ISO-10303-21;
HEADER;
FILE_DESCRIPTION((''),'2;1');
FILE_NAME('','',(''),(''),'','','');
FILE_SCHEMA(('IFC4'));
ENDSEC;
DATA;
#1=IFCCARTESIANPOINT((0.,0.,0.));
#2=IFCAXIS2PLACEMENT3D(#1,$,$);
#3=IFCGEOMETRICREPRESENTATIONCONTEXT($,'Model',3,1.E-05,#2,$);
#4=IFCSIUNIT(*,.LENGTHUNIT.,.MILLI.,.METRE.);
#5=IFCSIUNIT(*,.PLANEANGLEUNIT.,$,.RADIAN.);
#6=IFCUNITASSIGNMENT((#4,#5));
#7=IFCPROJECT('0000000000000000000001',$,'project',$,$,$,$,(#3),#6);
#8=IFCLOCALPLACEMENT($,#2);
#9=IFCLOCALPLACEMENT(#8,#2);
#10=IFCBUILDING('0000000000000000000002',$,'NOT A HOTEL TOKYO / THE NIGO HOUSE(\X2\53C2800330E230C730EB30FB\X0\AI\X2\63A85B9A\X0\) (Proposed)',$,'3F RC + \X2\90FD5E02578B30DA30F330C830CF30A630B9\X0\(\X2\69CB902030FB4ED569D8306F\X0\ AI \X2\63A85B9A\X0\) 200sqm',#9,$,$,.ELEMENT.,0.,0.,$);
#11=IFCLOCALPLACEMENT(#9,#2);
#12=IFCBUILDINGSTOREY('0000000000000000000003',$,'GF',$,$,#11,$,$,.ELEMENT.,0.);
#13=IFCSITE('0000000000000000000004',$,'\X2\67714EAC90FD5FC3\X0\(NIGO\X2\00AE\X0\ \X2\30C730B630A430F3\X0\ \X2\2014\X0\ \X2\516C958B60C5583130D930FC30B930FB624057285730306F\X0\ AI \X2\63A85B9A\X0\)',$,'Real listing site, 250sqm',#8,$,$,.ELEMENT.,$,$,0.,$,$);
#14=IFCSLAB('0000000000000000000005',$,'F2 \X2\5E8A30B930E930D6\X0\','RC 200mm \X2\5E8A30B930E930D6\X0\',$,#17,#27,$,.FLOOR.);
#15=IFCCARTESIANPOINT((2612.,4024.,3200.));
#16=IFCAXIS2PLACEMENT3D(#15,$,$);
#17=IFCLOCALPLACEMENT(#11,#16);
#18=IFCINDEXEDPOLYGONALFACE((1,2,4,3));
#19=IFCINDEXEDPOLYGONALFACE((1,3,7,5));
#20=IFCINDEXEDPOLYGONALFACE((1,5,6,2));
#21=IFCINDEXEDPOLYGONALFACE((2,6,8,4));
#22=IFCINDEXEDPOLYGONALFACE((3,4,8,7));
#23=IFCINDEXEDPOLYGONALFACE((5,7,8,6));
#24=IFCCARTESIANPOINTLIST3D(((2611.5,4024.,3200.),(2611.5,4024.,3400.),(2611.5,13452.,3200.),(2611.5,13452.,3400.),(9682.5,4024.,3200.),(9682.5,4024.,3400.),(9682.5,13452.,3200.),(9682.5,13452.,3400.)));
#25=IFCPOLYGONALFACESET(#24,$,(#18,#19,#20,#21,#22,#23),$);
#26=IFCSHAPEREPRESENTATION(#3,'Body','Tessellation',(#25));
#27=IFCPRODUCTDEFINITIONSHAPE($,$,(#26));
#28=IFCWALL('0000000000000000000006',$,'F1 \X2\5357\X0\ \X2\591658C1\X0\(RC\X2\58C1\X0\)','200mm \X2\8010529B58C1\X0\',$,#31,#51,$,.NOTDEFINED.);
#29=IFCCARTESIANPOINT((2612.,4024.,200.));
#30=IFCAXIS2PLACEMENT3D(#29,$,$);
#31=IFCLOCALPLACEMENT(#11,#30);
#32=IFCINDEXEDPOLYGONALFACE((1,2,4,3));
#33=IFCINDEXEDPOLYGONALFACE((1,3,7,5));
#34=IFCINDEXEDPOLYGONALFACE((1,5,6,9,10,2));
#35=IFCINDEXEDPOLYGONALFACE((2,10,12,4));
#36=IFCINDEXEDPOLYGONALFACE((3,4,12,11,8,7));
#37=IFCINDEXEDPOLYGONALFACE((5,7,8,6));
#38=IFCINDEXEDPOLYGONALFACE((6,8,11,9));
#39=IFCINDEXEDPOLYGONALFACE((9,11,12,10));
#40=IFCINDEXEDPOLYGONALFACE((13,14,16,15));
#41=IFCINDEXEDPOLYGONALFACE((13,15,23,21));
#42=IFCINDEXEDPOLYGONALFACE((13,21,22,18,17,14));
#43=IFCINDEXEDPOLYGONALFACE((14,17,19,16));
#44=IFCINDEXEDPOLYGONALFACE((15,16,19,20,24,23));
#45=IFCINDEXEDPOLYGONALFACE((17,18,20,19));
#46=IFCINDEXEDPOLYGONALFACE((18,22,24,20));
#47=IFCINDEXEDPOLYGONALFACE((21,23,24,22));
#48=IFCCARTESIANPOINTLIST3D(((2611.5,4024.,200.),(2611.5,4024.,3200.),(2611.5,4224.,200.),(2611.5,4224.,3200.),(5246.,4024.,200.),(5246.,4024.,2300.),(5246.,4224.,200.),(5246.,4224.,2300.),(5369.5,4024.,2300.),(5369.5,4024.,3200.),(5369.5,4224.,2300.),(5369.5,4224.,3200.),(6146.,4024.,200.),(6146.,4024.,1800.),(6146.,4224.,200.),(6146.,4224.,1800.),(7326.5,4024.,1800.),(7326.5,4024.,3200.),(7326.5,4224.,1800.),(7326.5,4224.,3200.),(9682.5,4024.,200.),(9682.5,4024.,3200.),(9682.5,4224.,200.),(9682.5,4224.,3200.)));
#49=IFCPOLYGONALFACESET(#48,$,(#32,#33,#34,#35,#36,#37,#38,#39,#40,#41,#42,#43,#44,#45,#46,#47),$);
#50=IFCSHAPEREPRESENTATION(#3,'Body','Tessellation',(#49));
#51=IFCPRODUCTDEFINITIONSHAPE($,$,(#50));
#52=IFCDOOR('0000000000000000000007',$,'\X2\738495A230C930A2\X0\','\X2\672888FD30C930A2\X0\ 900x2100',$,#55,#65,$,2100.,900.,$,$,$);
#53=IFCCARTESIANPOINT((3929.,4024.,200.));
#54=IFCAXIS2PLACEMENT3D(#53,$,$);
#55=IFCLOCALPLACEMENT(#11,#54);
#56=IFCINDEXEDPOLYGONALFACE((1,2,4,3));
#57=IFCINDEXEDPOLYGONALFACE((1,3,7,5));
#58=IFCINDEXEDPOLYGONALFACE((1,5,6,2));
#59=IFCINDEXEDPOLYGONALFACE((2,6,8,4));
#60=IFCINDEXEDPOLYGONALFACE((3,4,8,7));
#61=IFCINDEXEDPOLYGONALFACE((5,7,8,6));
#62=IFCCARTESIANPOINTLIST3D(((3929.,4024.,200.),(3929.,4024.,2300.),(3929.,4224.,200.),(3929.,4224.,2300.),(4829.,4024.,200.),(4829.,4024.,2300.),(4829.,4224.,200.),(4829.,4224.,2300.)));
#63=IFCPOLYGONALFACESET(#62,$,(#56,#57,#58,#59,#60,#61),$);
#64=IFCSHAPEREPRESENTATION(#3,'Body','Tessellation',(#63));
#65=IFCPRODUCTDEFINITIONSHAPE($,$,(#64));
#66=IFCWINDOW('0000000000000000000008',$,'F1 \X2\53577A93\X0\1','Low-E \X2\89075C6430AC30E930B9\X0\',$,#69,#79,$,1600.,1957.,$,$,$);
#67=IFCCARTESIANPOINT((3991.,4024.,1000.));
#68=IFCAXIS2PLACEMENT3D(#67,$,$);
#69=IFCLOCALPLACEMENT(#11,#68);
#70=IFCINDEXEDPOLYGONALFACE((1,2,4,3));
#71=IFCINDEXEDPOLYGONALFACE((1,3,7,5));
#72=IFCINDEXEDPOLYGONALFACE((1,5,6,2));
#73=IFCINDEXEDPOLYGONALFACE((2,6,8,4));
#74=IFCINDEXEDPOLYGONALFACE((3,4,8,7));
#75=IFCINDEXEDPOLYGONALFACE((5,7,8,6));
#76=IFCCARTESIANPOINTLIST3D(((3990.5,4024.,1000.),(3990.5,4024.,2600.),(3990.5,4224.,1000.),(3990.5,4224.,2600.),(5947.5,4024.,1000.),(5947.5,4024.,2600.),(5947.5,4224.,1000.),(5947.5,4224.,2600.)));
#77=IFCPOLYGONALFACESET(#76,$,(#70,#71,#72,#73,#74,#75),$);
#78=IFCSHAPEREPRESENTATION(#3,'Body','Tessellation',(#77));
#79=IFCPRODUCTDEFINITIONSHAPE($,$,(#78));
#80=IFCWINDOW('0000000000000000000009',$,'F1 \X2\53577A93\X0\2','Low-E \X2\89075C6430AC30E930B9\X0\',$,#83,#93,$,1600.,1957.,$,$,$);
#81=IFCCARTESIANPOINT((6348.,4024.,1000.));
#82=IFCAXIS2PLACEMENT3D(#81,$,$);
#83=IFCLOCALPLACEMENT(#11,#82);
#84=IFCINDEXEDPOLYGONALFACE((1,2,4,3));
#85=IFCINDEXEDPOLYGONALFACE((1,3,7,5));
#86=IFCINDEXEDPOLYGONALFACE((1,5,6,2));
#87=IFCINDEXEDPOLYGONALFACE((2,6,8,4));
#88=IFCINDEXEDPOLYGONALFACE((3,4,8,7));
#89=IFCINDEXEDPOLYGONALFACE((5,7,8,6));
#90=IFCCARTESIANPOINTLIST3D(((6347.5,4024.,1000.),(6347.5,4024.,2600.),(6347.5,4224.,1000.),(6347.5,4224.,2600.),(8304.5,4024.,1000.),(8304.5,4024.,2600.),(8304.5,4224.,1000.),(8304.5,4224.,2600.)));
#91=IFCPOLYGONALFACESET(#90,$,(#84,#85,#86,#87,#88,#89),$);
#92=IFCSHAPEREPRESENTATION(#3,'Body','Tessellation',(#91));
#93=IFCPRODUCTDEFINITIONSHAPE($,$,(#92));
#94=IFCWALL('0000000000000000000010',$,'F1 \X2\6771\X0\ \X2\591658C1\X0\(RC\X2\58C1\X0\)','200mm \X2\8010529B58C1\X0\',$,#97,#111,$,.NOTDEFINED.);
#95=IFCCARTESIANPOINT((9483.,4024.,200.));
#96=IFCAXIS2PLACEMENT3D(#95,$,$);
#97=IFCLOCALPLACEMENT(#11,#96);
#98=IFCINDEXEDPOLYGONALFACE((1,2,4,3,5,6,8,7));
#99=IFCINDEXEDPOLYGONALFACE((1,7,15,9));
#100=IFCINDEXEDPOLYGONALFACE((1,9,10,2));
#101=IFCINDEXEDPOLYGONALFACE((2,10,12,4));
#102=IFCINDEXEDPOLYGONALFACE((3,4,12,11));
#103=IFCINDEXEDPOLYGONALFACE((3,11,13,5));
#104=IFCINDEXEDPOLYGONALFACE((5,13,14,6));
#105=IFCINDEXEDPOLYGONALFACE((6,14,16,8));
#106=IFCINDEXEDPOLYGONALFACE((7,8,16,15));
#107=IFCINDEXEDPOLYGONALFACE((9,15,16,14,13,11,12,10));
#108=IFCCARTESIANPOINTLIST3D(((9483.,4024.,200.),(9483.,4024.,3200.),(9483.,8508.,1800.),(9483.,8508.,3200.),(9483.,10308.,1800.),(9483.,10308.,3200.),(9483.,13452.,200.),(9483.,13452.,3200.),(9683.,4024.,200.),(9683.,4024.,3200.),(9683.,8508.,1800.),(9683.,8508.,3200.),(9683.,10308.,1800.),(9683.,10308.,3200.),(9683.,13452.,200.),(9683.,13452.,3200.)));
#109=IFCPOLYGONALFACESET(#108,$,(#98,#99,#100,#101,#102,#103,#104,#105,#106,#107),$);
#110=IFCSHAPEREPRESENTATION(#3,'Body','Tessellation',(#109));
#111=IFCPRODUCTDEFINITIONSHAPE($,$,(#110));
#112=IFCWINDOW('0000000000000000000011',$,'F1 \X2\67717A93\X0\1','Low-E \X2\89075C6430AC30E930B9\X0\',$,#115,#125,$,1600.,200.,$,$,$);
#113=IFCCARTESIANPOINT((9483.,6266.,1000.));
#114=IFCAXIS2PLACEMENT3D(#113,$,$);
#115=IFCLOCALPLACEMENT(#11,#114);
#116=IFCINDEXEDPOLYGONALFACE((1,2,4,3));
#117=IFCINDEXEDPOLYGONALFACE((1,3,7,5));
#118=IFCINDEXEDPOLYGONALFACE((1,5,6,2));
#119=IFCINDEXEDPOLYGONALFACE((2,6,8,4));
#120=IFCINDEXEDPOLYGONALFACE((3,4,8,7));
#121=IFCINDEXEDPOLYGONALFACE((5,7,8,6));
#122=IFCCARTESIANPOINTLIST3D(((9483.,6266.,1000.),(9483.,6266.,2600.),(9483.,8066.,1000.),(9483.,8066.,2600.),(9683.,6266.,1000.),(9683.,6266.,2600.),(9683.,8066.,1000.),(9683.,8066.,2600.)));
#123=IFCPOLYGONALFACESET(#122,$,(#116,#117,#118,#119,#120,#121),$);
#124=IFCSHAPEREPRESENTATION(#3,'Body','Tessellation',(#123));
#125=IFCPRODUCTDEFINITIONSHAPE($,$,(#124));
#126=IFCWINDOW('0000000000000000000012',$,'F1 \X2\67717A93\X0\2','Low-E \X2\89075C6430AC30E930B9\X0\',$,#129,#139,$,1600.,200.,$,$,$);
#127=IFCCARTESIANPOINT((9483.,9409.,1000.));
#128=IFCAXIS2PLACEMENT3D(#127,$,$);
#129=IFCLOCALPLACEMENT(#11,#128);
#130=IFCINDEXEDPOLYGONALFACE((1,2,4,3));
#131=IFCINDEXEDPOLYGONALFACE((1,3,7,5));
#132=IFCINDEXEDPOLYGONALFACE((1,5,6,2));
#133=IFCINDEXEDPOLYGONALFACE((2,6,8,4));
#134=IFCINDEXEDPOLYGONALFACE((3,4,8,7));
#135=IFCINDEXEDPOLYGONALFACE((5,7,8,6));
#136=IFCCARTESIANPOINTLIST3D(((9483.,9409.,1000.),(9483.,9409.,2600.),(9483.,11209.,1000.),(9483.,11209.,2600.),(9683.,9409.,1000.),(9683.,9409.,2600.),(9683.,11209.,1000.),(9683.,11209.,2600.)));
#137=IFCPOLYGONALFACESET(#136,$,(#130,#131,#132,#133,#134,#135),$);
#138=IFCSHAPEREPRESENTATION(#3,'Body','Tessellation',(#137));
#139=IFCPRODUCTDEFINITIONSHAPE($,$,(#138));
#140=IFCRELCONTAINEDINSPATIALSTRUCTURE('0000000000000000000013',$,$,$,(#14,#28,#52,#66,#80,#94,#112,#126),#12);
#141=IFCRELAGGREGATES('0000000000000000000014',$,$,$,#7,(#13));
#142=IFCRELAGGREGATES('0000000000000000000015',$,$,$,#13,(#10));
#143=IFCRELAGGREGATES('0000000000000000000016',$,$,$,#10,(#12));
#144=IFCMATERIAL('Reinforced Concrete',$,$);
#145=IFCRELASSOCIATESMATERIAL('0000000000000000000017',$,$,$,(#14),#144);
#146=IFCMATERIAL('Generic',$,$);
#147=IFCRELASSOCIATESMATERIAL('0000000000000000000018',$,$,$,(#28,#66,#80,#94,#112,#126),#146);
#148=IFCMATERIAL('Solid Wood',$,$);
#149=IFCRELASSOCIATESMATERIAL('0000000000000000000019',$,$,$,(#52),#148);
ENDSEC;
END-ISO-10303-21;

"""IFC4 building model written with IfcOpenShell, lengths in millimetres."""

from ifc_helpers import new_model, si_unit, frame, frame_2d, origin, place, context, project, spatial, rectangle, extrude, material, element, fill, save


model = new_model("IFC4")

# Units and contexts
model_context = context("Model", 3, precision=1e-05, world=origin())
ifc_project = project(units=[si_unit("LENGTHUNIT", "METRE", prefix="MILLI"), si_unit("PLANEANGLEUNIT", "RADIAN")], contexts=[model_context])

# Site, building, storey
site_placement = place(None, origin())
site = spatial("IfcSite", under=ifc_project, at=site_placement, Name="東京都心(NIGO® デザイン — 公開情報ベース・所在地は AI 推定)", ObjectType="Real listing site, 250sqm", CompositionType="ELEMENT", RefElevation=0.0)
building_placement = place(site_placement, origin())
building = spatial("IfcBuilding", under=site, at=building_placement, Name="NOT A HOTEL TOKYO / THE NIGO HOUSE(参考モデル・AI推定) (Proposed)", ObjectType="3F RC + 都市型ペントハウス(構造・仕様は AI 推定) 200sqm", CompositionType="ELEMENT", ElevationOfRefHeight=0.0, ElevationOfTerrain=0.0)
storey_placement = place(building_placement, origin())
storey = spatial("IfcBuildingStorey", under=building, at=storey_placement, Name="GF", CompositionType="ELEMENT", Elevation=0.0)

# Slab
ifc_material_1 = material(Name="Reinforced Concrete")
slab_1_placement = place(storey_placement, frame((2612.0, 4024.0, 3200.0)))
element("IfcSlab", 1, at=slab_1_placement, inside=storey, material=ifc_material_1, Name="F2 床スラブ", Description="RC 200mm 床スラブ", PredefinedType="FLOOR", context=model_context, shape_type="SweptSolid", body=[
    extrude(rectangle(XDim=7071.0, YDim=9428.0, at=frame_2d((3535.0, 4714.0))), frame((2612.0, 4024.0, 3200.0)), (0.0, 0.0, 1.0), 200.0),
])

# Wall, openings, door, windows
ifc_material_2 = material(Name="Generic")
wall_1_placement = place(storey_placement, frame((2612.0, 4024.0, 200.0)))
wall_1 = element("IfcWall", 2, at=wall_1_placement, inside=storey, material=ifc_material_2, Name="F1 南 外壁(RC壁)", Description="200mm 耐力壁", PredefinedType="NOTDEFINED", context=model_context, shape_type="SweptSolid", body=[
    extrude(rectangle(XDim=7071.0, YDim=200.0, at=frame_2d((3535.0, 100.0))), frame((2612.0, 4024.0, 200.0)), (0.0, 0.0, 1.0), 3000.0),
])
opening_1_placement = place(storey_placement, frame((3929.0, 4024.0, 200.0)))
opening_1 = element("IfcOpeningElement", 3, at=opening_1_placement, cuts=wall_1, PredefinedType="NOTDEFINED", context=model_context, shape_type="SweptSolid", body=[
    extrude(rectangle(XDim=900.0, YDim=200.0, at=frame_2d((450.0, 100.0))), frame((3929.0, 4024.0, 200.0)), (0.0, 0.0, 1.0), 2100.0),
])
opening_2_placement = place(storey_placement, frame((3991.0, 4024.0, 1000.0)))
opening_2 = element("IfcOpeningElement", 4, at=opening_2_placement, cuts=wall_1, PredefinedType="NOTDEFINED", context=model_context, shape_type="SweptSolid", body=[
    extrude(rectangle(XDim=1957.0, YDim=200.0, at=frame_2d((978.0, 100.0))), frame((3991.0, 4024.0, 1000.0)), (0.0, 0.0, 1.0), 1600.0),
])
opening_3_placement = place(storey_placement, frame((6348.0, 4024.0, 1000.0)))
opening_3 = element("IfcOpeningElement", 5, at=opening_3_placement, cuts=wall_1, PredefinedType="NOTDEFINED", context=model_context, shape_type="SweptSolid", body=[
    extrude(rectangle(XDim=1957.0, YDim=200.0, at=frame_2d((978.0, 100.0))), frame((6348.0, 4024.0, 1000.0)), (0.0, 0.0, 1.0), 1600.0),
])
ifc_material_3 = material(Name="Solid Wood")
door_placement = place(storey_placement, frame((3929.0, 4024.0, 200.0)))
door = element("IfcDoor", 6, at=door_placement, inside=storey, material=ifc_material_3, Name="玄関ドア", Description="木製ドア 900x2100", OverallHeight=2100.0, OverallWidth=900.0, context=model_context, shape_type="SweptSolid", body=[
    extrude(rectangle(XDim=900.0, YDim=200.0, at=frame_2d((450.0, 100.0))), frame((3929.0, 4024.0, 200.0)), (0.0, 0.0, 1.0), 2100.0),
])
fill(opening_1, door)
window_1_placement = place(storey_placement, frame((3991.0, 4024.0, 1000.0)))
window_1 = element("IfcWindow", 7, at=window_1_placement, inside=storey, material=ifc_material_2, Name="F1 南窓1", Description="Low-E 複層ガラス", OverallHeight=1600.0, OverallWidth=1957.0, context=model_context, shape_type="SweptSolid", body=[
    extrude(rectangle(XDim=1957.0, YDim=200.0, at=frame_2d((978.0, 100.0))), frame((3991.0, 4024.0, 1000.0)), (0.0, 0.0, 1.0), 1600.0),
])
fill(opening_2, window_1)
window_2_placement = place(storey_placement, frame((6348.0, 4024.0, 1000.0)))
window_2 = element("IfcWindow", 8, at=window_2_placement, inside=storey, material=ifc_material_2, Name="F1 南窓2", Description="Low-E 複層ガラス", OverallHeight=1600.0, OverallWidth=1957.0, context=model_context, shape_type="SweptSolid", body=[
    extrude(rectangle(XDim=1957.0, YDim=200.0, at=frame_2d((978.0, 100.0))), frame((6348.0, 4024.0, 1000.0)), (0.0, 0.0, 1.0), 1600.0),
])
fill(opening_3, window_2)

# Wall, openings, windows
wall_2_placement = place(storey_placement, frame((9483.0, 4024.0, 200.0)))
wall_2 = element("IfcWall", 9, at=wall_2_placement, inside=storey, material=ifc_material_2, Name="F1 東 外壁(RC壁)", Description="200mm 耐力壁", PredefinedType="NOTDEFINED", context=model_context, shape_type="SweptSolid", body=[
    extrude(rectangle(XDim=200.0, YDim=9428.0, at=frame_2d((100.0, 4714.0))), frame((9483.0, 4024.0, 200.0)), (0.0, 0.0, 1.0), 3000.0),
])
opening_4_placement = place(storey_placement, frame((9483.0, 6266.0, 1000.0)))
opening_4 = element("IfcOpeningElement", 10, at=opening_4_placement, cuts=wall_2, PredefinedType="NOTDEFINED", context=model_context, shape_type="SweptSolid", body=[
    extrude(rectangle(XDim=200.0, YDim=1800.0, at=frame_2d((100.0, 900.0))), frame((9483.0, 6266.0, 1000.0)), (0.0, 0.0, 1.0), 1600.0),
])
opening_5_placement = place(storey_placement, frame((9483.0, 9409.0, 1000.0)))
opening_5 = element("IfcOpeningElement", 11, at=opening_5_placement, cuts=wall_2, PredefinedType="NOTDEFINED", context=model_context, shape_type="SweptSolid", body=[
    extrude(rectangle(XDim=200.0, YDim=1800.0, at=frame_2d((100.0, 900.0))), frame((9483.0, 9409.0, 1000.0)), (0.0, 0.0, 1.0), 1600.0),
])
window_3_placement = place(storey_placement, frame((9483.0, 6266.0, 1000.0)))
window_3 = element("IfcWindow", 12, at=window_3_placement, inside=storey, material=ifc_material_2, Name="F1 東窓1", Description="Low-E 複層ガラス", OverallHeight=1600.0, OverallWidth=200.0, context=model_context, shape_type="SweptSolid", body=[
    extrude(rectangle(XDim=200.0, YDim=1800.0, at=frame_2d((100.0, 900.0))), frame((9483.0, 6266.0, 1000.0)), (0.0, 0.0, 1.0), 1600.0),
])
fill(opening_4, window_3)
window_4_placement = place(storey_placement, frame((9483.0, 9409.0, 1000.0)))
window_4 = element("IfcWindow", 13, at=window_4_placement, inside=storey, material=ifc_material_2, Name="F1 東窓2", Description="Low-E 複層ガラス", OverallHeight=1600.0, OverallWidth=200.0, context=model_context, shape_type="SweptSolid", body=[
    extrude(rectangle(XDim=200.0, YDim=1800.0, at=frame_2d((100.0, 900.0))), frame((9483.0, 9409.0, 1000.0)), (0.0, 0.0, 1.0), 1600.0),
])
fill(opening_5, window_4)

save(model, "model.ifc")
